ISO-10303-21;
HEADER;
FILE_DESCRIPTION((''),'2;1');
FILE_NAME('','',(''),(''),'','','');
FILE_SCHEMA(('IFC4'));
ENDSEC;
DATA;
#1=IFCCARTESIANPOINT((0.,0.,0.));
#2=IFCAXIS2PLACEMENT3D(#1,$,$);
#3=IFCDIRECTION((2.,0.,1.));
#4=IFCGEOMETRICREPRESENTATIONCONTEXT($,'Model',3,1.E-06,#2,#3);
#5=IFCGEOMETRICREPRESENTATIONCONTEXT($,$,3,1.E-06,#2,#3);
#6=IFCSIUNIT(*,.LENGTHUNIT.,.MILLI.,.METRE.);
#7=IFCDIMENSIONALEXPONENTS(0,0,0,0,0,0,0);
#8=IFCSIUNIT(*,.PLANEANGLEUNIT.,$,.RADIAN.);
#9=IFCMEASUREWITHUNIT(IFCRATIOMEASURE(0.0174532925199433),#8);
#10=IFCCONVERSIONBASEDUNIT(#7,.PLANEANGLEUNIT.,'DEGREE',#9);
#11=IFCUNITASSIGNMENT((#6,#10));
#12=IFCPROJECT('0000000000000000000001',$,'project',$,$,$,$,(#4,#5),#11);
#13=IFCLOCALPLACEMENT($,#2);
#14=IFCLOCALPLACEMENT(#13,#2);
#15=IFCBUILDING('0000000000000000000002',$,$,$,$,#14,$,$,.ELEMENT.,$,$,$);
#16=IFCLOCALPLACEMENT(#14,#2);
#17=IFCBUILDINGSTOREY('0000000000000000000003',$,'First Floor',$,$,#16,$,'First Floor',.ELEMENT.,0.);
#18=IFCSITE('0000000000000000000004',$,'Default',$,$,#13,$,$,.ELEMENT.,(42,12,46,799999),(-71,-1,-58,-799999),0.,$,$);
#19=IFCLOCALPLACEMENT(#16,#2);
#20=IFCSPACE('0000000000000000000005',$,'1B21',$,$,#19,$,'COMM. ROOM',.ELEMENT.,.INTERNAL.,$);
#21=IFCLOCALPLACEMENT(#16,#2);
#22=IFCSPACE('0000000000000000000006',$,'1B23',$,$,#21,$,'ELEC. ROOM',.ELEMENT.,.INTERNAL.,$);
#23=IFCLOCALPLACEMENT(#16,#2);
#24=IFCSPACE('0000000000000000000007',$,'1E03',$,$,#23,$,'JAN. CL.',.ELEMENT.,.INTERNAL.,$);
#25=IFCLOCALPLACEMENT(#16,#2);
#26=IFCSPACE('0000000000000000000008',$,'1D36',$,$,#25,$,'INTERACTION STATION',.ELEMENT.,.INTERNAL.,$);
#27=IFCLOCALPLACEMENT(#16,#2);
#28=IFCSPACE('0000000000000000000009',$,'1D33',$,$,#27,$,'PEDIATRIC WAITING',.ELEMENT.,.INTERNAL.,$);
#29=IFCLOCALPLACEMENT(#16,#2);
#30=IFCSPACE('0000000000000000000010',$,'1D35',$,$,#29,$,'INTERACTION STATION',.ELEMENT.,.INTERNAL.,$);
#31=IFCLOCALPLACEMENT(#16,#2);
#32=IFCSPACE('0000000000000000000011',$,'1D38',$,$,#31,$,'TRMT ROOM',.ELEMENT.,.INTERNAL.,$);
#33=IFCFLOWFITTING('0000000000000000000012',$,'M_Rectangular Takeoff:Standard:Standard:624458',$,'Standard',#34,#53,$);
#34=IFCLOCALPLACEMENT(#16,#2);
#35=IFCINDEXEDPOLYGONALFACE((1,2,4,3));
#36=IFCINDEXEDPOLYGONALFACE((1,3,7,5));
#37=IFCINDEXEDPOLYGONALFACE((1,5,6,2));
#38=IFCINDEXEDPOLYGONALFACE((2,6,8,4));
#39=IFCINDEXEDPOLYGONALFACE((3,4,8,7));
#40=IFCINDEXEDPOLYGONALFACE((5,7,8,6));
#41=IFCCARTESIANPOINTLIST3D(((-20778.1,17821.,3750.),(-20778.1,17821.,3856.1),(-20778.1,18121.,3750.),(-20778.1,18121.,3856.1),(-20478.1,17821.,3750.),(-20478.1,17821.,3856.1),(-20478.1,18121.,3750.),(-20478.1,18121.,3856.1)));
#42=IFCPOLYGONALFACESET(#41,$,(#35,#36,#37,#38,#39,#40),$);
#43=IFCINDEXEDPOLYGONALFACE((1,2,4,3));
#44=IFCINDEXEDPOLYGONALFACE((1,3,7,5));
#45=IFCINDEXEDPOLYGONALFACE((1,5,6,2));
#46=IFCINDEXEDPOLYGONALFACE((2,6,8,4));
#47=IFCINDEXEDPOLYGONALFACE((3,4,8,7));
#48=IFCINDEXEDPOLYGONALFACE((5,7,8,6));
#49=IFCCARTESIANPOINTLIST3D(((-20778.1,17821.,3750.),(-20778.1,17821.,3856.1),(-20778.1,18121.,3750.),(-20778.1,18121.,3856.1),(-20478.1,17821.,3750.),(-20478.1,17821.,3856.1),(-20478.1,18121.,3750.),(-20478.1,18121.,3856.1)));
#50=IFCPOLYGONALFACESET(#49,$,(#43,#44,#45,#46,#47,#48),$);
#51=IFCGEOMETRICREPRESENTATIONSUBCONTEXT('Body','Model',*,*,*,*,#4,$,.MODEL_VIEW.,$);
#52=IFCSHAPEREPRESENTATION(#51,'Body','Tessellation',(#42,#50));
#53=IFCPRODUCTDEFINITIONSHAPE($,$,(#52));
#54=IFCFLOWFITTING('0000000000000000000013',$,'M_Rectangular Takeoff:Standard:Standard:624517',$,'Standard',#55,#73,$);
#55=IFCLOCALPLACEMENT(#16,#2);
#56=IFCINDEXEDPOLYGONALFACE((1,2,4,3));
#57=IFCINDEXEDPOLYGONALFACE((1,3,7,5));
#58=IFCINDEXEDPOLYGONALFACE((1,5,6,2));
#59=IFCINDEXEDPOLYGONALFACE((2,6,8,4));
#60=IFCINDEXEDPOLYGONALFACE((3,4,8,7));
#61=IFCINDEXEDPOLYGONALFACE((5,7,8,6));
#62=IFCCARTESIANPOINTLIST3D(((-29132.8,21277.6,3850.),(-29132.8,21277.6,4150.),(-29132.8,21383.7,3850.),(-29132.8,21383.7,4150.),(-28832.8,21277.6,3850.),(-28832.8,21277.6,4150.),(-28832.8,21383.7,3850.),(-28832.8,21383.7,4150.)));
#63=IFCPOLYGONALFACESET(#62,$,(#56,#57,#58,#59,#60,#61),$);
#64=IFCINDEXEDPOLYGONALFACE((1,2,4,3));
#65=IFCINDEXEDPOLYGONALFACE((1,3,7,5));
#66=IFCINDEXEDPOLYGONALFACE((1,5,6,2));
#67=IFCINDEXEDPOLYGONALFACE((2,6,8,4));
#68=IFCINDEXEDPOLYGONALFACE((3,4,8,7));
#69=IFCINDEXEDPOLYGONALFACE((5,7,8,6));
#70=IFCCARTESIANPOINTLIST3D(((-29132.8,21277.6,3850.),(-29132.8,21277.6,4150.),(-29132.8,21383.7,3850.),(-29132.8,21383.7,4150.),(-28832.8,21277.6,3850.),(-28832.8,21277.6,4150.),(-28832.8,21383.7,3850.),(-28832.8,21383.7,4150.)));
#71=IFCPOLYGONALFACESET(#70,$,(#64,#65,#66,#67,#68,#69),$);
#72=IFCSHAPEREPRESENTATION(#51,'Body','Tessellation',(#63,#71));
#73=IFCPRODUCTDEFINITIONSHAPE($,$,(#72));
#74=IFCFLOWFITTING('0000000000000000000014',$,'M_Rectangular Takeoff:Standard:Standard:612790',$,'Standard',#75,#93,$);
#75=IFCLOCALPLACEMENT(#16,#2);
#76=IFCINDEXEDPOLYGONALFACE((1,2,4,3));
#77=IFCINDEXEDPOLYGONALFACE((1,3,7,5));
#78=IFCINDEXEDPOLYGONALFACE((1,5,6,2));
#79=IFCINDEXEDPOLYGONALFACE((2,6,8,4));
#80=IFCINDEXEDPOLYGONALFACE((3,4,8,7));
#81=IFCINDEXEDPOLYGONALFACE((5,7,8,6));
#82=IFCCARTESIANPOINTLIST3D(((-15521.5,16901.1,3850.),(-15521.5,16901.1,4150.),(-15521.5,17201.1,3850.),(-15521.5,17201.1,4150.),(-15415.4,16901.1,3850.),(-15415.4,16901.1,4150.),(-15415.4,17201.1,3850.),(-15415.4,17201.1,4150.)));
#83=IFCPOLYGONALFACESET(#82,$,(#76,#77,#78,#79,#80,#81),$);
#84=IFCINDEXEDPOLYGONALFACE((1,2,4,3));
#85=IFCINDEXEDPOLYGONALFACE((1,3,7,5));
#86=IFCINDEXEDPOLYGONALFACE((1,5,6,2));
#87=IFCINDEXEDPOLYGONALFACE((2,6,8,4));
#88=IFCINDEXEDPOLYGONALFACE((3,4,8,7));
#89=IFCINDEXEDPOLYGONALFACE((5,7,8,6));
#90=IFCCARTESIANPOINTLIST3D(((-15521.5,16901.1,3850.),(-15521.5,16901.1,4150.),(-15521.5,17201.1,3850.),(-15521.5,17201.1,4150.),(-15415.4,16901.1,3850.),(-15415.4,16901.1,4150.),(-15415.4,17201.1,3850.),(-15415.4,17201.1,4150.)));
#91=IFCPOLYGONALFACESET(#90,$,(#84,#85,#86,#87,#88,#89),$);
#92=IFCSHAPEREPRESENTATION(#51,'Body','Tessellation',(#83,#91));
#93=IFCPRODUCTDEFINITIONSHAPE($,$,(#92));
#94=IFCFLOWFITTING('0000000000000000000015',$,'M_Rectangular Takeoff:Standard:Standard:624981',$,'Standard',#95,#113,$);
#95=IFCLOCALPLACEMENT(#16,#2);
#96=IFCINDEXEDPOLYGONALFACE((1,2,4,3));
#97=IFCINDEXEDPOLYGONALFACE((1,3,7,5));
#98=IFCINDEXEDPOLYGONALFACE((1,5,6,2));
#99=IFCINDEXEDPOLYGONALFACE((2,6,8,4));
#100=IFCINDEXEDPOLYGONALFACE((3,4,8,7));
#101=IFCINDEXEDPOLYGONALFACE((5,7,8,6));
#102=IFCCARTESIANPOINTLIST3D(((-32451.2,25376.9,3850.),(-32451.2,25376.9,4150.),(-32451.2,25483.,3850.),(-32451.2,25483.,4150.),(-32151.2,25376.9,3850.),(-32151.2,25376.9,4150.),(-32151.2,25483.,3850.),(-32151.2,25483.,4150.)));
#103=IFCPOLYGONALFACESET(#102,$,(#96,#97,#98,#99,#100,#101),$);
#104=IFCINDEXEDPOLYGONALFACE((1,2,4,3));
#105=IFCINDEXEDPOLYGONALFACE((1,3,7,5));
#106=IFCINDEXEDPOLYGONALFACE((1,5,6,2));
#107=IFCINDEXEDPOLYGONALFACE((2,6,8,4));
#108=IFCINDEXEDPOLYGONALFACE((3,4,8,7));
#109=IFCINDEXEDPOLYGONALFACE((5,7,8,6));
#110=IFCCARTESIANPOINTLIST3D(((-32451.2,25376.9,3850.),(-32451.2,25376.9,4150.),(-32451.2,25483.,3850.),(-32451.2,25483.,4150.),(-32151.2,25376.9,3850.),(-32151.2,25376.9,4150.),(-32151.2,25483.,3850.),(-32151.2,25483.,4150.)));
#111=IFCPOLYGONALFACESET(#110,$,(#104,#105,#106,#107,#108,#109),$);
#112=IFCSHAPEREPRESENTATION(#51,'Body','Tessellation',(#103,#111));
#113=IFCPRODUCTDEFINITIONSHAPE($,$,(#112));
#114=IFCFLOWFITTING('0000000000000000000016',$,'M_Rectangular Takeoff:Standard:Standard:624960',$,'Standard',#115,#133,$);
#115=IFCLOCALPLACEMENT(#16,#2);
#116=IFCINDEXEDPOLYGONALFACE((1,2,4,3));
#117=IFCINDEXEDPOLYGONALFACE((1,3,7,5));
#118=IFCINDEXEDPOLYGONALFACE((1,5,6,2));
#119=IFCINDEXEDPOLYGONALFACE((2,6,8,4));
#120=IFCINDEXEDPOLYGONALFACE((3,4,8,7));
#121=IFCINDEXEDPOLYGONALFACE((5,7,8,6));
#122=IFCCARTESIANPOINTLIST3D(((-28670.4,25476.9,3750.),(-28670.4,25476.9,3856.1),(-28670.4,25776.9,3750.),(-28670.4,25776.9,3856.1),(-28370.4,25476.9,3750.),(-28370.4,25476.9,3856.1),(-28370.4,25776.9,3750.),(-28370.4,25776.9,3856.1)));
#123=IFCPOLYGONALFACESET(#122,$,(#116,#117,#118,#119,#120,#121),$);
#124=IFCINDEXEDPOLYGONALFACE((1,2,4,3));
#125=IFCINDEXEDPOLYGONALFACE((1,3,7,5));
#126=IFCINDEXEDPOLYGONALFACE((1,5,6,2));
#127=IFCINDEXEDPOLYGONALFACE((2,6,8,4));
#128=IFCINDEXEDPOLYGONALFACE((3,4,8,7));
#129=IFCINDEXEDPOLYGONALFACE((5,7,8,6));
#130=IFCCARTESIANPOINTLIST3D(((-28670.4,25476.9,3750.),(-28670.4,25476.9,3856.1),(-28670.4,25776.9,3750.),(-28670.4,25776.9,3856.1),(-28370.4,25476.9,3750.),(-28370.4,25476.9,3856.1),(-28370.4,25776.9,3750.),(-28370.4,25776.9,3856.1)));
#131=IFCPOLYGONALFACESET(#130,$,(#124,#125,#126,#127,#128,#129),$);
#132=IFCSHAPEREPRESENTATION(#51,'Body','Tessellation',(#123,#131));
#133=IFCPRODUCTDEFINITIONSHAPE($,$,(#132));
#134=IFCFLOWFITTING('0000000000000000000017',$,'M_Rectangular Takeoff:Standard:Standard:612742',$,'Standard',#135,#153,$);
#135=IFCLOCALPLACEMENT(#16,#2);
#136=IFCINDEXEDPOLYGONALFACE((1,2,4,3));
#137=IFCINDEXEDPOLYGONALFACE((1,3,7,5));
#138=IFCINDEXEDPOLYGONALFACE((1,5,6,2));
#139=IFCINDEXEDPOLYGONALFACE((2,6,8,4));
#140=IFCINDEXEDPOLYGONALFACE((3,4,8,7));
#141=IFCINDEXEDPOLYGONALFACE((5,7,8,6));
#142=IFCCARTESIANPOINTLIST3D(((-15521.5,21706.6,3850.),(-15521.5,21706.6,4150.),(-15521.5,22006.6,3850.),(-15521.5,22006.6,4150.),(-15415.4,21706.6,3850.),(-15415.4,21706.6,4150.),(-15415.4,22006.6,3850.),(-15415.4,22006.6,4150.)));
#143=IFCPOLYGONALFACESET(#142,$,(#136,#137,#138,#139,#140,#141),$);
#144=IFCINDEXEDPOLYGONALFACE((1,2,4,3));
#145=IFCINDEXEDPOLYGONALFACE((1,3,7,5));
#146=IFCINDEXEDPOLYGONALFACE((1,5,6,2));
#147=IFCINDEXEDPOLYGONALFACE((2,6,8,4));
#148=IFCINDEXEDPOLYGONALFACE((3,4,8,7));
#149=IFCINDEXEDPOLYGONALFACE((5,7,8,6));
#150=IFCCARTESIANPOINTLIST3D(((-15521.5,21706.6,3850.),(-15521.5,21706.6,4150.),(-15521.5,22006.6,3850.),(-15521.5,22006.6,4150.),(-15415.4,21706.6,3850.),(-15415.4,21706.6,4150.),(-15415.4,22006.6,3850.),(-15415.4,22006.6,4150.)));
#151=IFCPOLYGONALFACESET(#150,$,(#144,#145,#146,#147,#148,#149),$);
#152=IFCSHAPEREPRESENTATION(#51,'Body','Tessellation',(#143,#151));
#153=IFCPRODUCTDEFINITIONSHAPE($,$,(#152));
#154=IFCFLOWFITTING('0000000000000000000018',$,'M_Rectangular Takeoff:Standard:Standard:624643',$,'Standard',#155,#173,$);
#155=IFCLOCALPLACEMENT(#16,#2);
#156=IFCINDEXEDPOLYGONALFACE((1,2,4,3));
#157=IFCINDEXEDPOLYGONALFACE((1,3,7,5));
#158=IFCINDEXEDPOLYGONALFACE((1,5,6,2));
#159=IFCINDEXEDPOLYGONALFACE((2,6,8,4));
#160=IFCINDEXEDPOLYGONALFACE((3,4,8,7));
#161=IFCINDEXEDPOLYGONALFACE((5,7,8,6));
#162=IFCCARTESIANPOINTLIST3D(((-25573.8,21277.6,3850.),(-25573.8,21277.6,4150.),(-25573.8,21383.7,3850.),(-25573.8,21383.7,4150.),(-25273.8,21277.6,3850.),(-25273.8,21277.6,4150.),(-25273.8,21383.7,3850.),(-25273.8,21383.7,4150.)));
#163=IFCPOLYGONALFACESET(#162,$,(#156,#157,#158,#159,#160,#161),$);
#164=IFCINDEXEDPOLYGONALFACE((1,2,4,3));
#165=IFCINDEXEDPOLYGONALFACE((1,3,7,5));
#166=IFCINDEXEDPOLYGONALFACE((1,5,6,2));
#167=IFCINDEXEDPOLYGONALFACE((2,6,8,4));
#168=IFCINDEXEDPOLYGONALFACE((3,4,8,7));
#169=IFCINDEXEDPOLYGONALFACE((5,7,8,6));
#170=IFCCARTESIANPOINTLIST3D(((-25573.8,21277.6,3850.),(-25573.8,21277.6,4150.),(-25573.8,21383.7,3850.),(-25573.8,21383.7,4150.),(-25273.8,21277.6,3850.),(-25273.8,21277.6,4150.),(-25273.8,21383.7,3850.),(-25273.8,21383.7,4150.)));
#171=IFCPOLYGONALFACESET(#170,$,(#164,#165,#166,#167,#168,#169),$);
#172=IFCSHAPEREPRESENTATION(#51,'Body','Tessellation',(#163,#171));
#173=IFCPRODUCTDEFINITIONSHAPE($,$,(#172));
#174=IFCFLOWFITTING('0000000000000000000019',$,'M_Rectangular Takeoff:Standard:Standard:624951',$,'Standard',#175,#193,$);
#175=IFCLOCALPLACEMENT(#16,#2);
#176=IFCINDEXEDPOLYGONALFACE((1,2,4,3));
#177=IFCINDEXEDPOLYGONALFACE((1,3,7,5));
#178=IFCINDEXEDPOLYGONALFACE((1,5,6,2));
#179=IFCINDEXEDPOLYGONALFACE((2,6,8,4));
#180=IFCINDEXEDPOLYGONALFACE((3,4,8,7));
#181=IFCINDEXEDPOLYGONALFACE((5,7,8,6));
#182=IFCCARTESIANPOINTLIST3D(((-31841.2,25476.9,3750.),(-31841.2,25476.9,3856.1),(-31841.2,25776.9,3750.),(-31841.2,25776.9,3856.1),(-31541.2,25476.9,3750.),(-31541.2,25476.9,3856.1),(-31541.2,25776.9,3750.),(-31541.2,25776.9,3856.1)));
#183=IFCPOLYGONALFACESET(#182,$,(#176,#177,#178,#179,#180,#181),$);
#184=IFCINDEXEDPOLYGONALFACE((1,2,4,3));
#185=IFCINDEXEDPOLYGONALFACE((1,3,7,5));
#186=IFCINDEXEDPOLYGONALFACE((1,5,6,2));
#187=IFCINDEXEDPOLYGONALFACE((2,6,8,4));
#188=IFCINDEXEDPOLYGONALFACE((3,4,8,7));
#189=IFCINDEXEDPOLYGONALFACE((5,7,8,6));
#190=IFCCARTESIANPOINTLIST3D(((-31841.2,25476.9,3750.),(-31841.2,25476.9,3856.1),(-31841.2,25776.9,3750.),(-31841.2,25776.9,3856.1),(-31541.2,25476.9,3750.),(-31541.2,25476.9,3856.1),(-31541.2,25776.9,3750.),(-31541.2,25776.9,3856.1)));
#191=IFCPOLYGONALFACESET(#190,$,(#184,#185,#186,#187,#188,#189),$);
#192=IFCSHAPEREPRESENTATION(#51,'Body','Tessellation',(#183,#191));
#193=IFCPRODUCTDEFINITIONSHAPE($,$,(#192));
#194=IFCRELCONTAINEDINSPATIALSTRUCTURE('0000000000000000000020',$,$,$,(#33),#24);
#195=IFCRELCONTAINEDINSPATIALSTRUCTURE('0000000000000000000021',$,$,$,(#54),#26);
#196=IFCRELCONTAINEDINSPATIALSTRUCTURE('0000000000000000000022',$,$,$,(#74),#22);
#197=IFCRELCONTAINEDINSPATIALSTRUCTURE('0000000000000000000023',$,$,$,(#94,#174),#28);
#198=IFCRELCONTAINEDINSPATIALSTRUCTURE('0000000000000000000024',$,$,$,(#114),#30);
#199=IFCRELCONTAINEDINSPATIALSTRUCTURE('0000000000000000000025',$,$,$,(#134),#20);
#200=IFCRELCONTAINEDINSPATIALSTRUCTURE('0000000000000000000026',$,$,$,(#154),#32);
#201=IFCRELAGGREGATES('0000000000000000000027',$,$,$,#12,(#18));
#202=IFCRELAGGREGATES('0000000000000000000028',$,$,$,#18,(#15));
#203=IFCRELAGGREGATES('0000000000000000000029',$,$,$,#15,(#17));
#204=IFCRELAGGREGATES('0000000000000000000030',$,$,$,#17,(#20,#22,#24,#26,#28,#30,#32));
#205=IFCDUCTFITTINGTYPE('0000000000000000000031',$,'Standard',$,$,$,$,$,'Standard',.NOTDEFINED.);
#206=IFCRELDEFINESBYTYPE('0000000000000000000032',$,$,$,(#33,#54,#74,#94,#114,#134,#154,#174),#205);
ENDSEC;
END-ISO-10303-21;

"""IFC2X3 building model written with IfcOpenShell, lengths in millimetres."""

from ifc_helpers import new_model, entity, si_unit, converted_unit, direction, frame, frame_2d, origin, place, context, subcontext, project, spatial, rectangle, extrude, source, transform, mapped, type_object, type_shapes, element, save


model = new_model("IFC2X3")

# Units and contexts
model_context = context("Model", 3, precision=1e-06, world=origin(), true_north=direction((2.0, 0.0, 1.0)))
context_of_model = context(None, 3, precision=1e-06, world=origin(), true_north=direction((2.0, 0.0, 1.0)))
body_context = subcontext(model_context, "Body", "Model", "MODEL_VIEW")
ifc_project = project(units=[si_unit("LENGTHUNIT", "METRE", prefix="MILLI"), converted_unit("PLANEANGLEUNIT", "DEGREE", entity("IfcRatioMeasure", 0.0174532925199433), si_unit("PLANEANGLEUNIT", "RADIAN"), dimensions=[0, 0, 0, 0, 0, 0, 0])], contexts=[model_context, context_of_model])

# Site, building, storey, space
site_placement = place(None, origin())
site = spatial("IfcSite", under=ifc_project, at=site_placement, Name="Default", CompositionType="ELEMENT", RefLatitude=(42, 12, 46, 799999), RefLongitude=(-71, -1, -58, -799999), RefElevation=0.0)
building_placement = place(site_placement, origin())
building = spatial("IfcBuilding", under=site, at=building_placement, CompositionType="ELEMENT")
storey_placement = place(building_placement, origin())
storey = spatial("IfcBuildingStorey", under=building, at=storey_placement, Name="First Floor", LongName="First Floor", CompositionType="ELEMENT", Elevation=0.0)
space_1_placement = place(storey_placement, origin())
space_1 = spatial("IfcSpace", under=storey, at=space_1_placement, Name="1B21", LongName="COMM. ROOM", CompositionType="ELEMENT", InteriorOrExteriorSpace="INTERNAL")

# Shared definitions
space_2_placement = place(storey_placement, origin())
space_2 = spatial("IfcSpace", under=storey, at=space_2_placement, Name="1B23", LongName="ELEC. ROOM", CompositionType="ELEMENT", InteriorOrExteriorSpace="INTERNAL")

# Shared definitions
space_3_placement = place(storey_placement, origin())
space_3 = spatial("IfcSpace", under=storey, at=space_3_placement, Name="1E03", LongName="JAN. CL.", CompositionType="ELEMENT", InteriorOrExteriorSpace="INTERNAL")

# Flow fitting
duct_fitting_type_1 = type_object("IfcDuctFittingType", Name="Standard", ElementType="Standard", PredefinedType="NOTDEFINED")
shared_shape_1 = source(origin(), body_context, "Body", "SweptSolid", [
    extrude(rectangle(XDim=300.0, YDim=106.1, at=frame_2d((0.0, 0.0), x_axis=(1.0, 0.0))), frame((47.0, 0.0, -150.0), z_axis=(0.0, 0.0, 1.0), x_axis=(0.0, -1.0, 0.0)), (0.0, 0.0, 1.0), 300.0),
    extrude(rectangle(XDim=300.0, YDim=106.1, at=frame_2d((0.0, 0.0), x_axis=(1.0, 0.0))), frame((47.0, 0.0, -150.0), z_axis=(0.0, 0.0, 1.0), x_axis=(0.0, -1.0, 0.0)), (0.0, 0.0, 1.0), 300.0),
])
type_shapes(duct_fitting_type_1, [shared_shape_1])
flow_fitting_1_placement = place(space_3_placement, frame((-20628.1, 17971.0, 3850.0), z_axis=(0.0, 1.0, 0.0), x_axis=(0.0, 0.0, -1.0)))
element("IfcFlowFitting", 1, at=flow_fitting_1_placement, inside=space_3, type_object=duct_fitting_type_1, Name="M_Rectangular Takeoff:Standard:Standard:624458", ObjectType="Standard", context=body_context, shape_type="MappedRepresentation", body=[
    mapped(shared_shape_1, transform((0.0, 0.0, 0.0), scale=1.0)),
])

# Shared definitions
space_4_placement = place(storey_placement, origin())
space_4 = spatial("IfcSpace", under=storey, at=space_4_placement, Name="1D36", LongName="INTERACTION STATION", CompositionType="ELEMENT", InteriorOrExteriorSpace="INTERNAL")

# Flow fittings
flow_fitting_2_placement = place(space_4_placement, frame((-28982.8, 21377.6, 4000.0), z_axis=(0.0, 0.0, -1.0), x_axis=(0.0, -1.0, 0.0)))
element("IfcFlowFitting", 2, at=flow_fitting_2_placement, inside=space_4, type_object=duct_fitting_type_1, Name="M_Rectangular Takeoff:Standard:Standard:624517", ObjectType="Standard", context=body_context, shape_type="MappedRepresentation", body=[
    mapped(shared_shape_1, transform((0.0, 0.0, 0.0), scale=1.0)),
])
flow_fitting_3_placement = place(space_2_placement, frame((-15515.4, 17051.1, 4000.0), z_axis=(0.0, 0.0, -1.0), x_axis=(1.0, 0.0, 0.0)))
element("IfcFlowFitting", 3, at=flow_fitting_3_placement, inside=space_2, type_object=duct_fitting_type_1, Name="M_Rectangular Takeoff:Standard:Standard:612790", ObjectType="Standard", context=body_context, shape_type="MappedRepresentation", body=[
    mapped(shared_shape_1, transform((0.0, 0.0, 0.0), scale=1.0)),
])

# Shared definitions
space_5_placement = place(storey_placement, origin())
space_5 = spatial("IfcSpace", under=storey, at=space_5_placement, Name="1D33", LongName="PEDIATRIC WAITING", CompositionType="ELEMENT", InteriorOrExteriorSpace="INTERNAL")

# Flow fitting
flow_fitting_4_placement = place(space_5_placement, frame((-32301.2, 25476.9, 4000.0), z_axis=(0.0, 0.0, -1.0), x_axis=(0.0, -1.0, 0.0)))
element("IfcFlowFitting", 4, at=flow_fitting_4_placement, inside=space_5, type_object=duct_fitting_type_1, Name="M_Rectangular Takeoff:Standard:Standard:624981", ObjectType="Standard", context=body_context, shape_type="MappedRepresentation", body=[
    mapped(shared_shape_1, transform((0.0, 0.0, 0.0), scale=1.0)),
])

# Shared definitions
space_6_placement = place(storey_placement, origin())
space_6 = spatial("IfcSpace", under=storey, at=space_6_placement, Name="1D35", LongName="INTERACTION STATION", CompositionType="ELEMENT", InteriorOrExteriorSpace="INTERNAL")

# Flow fittings
flow_fitting_5_placement = place(space_6_placement, frame((-28520.4, 25626.9, 3850.0), z_axis=(1.0, 0.0, 0.0), x_axis=(0.0, 0.0, -1.0)))
element("IfcFlowFitting", 5, at=flow_fitting_5_placement, inside=space_6, type_object=duct_fitting_type_1, Name="M_Rectangular Takeoff:Standard:Standard:624960", ObjectType="Standard", context=body_context, shape_type="MappedRepresentation", body=[
    mapped(shared_shape_1, transform((0.0, 0.0, 0.0), scale=1.0)),
])
flow_fitting_6_placement = place(space_1_placement, frame((-15515.4, 21856.6, 4000.0), z_axis=(0.0, 0.0, -1.0), x_axis=(1.0, 0.0, 0.0)))
element("IfcFlowFitting", 6, at=flow_fitting_6_placement, inside=space_1, type_object=duct_fitting_type_1, Name="M_Rectangular Takeoff:Standard:Standard:612742", ObjectType="Standard", context=body_context, shape_type="MappedRepresentation", body=[
    mapped(shared_shape_1, transform((0.0, 0.0, 0.0), scale=1.0)),
])

# Shared definitions
space_7_placement = place(storey_placement, origin())
space_7 = spatial("IfcSpace", under=storey, at=space_7_placement, Name="1D38", LongName="TRMT ROOM", CompositionType="ELEMENT", InteriorOrExteriorSpace="INTERNAL")

# Flow fittings
flow_fitting_7_placement = place(space_7_placement, frame((-25423.8, 21377.6, 4000.0), z_axis=(0.0, 0.0, -1.0), x_axis=(0.0, -1.0, 0.0)))
element("IfcFlowFitting", 7, at=flow_fitting_7_placement, inside=space_7, type_object=duct_fitting_type_1, Name="M_Rectangular Takeoff:Standard:Standard:624643", ObjectType="Standard", context=body_context, shape_type="MappedRepresentation", body=[
    mapped(shared_shape_1, transform((0.0, 0.0, 0.0), scale=1.0)),
])
flow_fitting_8_placement = place(space_5_placement, frame((-31691.2, 25626.9, 3850.0), z_axis=(1.0, 0.0, 0.0), x_axis=(0.0, 0.0, -1.0)))
element("IfcFlowFitting", 8, at=flow_fitting_8_placement, inside=space_5, type_object=duct_fitting_type_1, Name="M_Rectangular Takeoff:Standard:Standard:624951", ObjectType="Standard", context=body_context, shape_type="MappedRepresentation", body=[
    mapped(shared_shape_1, transform((0.0, 0.0, 0.0), scale=1.0)),
])

save(model, "model.ifc")
